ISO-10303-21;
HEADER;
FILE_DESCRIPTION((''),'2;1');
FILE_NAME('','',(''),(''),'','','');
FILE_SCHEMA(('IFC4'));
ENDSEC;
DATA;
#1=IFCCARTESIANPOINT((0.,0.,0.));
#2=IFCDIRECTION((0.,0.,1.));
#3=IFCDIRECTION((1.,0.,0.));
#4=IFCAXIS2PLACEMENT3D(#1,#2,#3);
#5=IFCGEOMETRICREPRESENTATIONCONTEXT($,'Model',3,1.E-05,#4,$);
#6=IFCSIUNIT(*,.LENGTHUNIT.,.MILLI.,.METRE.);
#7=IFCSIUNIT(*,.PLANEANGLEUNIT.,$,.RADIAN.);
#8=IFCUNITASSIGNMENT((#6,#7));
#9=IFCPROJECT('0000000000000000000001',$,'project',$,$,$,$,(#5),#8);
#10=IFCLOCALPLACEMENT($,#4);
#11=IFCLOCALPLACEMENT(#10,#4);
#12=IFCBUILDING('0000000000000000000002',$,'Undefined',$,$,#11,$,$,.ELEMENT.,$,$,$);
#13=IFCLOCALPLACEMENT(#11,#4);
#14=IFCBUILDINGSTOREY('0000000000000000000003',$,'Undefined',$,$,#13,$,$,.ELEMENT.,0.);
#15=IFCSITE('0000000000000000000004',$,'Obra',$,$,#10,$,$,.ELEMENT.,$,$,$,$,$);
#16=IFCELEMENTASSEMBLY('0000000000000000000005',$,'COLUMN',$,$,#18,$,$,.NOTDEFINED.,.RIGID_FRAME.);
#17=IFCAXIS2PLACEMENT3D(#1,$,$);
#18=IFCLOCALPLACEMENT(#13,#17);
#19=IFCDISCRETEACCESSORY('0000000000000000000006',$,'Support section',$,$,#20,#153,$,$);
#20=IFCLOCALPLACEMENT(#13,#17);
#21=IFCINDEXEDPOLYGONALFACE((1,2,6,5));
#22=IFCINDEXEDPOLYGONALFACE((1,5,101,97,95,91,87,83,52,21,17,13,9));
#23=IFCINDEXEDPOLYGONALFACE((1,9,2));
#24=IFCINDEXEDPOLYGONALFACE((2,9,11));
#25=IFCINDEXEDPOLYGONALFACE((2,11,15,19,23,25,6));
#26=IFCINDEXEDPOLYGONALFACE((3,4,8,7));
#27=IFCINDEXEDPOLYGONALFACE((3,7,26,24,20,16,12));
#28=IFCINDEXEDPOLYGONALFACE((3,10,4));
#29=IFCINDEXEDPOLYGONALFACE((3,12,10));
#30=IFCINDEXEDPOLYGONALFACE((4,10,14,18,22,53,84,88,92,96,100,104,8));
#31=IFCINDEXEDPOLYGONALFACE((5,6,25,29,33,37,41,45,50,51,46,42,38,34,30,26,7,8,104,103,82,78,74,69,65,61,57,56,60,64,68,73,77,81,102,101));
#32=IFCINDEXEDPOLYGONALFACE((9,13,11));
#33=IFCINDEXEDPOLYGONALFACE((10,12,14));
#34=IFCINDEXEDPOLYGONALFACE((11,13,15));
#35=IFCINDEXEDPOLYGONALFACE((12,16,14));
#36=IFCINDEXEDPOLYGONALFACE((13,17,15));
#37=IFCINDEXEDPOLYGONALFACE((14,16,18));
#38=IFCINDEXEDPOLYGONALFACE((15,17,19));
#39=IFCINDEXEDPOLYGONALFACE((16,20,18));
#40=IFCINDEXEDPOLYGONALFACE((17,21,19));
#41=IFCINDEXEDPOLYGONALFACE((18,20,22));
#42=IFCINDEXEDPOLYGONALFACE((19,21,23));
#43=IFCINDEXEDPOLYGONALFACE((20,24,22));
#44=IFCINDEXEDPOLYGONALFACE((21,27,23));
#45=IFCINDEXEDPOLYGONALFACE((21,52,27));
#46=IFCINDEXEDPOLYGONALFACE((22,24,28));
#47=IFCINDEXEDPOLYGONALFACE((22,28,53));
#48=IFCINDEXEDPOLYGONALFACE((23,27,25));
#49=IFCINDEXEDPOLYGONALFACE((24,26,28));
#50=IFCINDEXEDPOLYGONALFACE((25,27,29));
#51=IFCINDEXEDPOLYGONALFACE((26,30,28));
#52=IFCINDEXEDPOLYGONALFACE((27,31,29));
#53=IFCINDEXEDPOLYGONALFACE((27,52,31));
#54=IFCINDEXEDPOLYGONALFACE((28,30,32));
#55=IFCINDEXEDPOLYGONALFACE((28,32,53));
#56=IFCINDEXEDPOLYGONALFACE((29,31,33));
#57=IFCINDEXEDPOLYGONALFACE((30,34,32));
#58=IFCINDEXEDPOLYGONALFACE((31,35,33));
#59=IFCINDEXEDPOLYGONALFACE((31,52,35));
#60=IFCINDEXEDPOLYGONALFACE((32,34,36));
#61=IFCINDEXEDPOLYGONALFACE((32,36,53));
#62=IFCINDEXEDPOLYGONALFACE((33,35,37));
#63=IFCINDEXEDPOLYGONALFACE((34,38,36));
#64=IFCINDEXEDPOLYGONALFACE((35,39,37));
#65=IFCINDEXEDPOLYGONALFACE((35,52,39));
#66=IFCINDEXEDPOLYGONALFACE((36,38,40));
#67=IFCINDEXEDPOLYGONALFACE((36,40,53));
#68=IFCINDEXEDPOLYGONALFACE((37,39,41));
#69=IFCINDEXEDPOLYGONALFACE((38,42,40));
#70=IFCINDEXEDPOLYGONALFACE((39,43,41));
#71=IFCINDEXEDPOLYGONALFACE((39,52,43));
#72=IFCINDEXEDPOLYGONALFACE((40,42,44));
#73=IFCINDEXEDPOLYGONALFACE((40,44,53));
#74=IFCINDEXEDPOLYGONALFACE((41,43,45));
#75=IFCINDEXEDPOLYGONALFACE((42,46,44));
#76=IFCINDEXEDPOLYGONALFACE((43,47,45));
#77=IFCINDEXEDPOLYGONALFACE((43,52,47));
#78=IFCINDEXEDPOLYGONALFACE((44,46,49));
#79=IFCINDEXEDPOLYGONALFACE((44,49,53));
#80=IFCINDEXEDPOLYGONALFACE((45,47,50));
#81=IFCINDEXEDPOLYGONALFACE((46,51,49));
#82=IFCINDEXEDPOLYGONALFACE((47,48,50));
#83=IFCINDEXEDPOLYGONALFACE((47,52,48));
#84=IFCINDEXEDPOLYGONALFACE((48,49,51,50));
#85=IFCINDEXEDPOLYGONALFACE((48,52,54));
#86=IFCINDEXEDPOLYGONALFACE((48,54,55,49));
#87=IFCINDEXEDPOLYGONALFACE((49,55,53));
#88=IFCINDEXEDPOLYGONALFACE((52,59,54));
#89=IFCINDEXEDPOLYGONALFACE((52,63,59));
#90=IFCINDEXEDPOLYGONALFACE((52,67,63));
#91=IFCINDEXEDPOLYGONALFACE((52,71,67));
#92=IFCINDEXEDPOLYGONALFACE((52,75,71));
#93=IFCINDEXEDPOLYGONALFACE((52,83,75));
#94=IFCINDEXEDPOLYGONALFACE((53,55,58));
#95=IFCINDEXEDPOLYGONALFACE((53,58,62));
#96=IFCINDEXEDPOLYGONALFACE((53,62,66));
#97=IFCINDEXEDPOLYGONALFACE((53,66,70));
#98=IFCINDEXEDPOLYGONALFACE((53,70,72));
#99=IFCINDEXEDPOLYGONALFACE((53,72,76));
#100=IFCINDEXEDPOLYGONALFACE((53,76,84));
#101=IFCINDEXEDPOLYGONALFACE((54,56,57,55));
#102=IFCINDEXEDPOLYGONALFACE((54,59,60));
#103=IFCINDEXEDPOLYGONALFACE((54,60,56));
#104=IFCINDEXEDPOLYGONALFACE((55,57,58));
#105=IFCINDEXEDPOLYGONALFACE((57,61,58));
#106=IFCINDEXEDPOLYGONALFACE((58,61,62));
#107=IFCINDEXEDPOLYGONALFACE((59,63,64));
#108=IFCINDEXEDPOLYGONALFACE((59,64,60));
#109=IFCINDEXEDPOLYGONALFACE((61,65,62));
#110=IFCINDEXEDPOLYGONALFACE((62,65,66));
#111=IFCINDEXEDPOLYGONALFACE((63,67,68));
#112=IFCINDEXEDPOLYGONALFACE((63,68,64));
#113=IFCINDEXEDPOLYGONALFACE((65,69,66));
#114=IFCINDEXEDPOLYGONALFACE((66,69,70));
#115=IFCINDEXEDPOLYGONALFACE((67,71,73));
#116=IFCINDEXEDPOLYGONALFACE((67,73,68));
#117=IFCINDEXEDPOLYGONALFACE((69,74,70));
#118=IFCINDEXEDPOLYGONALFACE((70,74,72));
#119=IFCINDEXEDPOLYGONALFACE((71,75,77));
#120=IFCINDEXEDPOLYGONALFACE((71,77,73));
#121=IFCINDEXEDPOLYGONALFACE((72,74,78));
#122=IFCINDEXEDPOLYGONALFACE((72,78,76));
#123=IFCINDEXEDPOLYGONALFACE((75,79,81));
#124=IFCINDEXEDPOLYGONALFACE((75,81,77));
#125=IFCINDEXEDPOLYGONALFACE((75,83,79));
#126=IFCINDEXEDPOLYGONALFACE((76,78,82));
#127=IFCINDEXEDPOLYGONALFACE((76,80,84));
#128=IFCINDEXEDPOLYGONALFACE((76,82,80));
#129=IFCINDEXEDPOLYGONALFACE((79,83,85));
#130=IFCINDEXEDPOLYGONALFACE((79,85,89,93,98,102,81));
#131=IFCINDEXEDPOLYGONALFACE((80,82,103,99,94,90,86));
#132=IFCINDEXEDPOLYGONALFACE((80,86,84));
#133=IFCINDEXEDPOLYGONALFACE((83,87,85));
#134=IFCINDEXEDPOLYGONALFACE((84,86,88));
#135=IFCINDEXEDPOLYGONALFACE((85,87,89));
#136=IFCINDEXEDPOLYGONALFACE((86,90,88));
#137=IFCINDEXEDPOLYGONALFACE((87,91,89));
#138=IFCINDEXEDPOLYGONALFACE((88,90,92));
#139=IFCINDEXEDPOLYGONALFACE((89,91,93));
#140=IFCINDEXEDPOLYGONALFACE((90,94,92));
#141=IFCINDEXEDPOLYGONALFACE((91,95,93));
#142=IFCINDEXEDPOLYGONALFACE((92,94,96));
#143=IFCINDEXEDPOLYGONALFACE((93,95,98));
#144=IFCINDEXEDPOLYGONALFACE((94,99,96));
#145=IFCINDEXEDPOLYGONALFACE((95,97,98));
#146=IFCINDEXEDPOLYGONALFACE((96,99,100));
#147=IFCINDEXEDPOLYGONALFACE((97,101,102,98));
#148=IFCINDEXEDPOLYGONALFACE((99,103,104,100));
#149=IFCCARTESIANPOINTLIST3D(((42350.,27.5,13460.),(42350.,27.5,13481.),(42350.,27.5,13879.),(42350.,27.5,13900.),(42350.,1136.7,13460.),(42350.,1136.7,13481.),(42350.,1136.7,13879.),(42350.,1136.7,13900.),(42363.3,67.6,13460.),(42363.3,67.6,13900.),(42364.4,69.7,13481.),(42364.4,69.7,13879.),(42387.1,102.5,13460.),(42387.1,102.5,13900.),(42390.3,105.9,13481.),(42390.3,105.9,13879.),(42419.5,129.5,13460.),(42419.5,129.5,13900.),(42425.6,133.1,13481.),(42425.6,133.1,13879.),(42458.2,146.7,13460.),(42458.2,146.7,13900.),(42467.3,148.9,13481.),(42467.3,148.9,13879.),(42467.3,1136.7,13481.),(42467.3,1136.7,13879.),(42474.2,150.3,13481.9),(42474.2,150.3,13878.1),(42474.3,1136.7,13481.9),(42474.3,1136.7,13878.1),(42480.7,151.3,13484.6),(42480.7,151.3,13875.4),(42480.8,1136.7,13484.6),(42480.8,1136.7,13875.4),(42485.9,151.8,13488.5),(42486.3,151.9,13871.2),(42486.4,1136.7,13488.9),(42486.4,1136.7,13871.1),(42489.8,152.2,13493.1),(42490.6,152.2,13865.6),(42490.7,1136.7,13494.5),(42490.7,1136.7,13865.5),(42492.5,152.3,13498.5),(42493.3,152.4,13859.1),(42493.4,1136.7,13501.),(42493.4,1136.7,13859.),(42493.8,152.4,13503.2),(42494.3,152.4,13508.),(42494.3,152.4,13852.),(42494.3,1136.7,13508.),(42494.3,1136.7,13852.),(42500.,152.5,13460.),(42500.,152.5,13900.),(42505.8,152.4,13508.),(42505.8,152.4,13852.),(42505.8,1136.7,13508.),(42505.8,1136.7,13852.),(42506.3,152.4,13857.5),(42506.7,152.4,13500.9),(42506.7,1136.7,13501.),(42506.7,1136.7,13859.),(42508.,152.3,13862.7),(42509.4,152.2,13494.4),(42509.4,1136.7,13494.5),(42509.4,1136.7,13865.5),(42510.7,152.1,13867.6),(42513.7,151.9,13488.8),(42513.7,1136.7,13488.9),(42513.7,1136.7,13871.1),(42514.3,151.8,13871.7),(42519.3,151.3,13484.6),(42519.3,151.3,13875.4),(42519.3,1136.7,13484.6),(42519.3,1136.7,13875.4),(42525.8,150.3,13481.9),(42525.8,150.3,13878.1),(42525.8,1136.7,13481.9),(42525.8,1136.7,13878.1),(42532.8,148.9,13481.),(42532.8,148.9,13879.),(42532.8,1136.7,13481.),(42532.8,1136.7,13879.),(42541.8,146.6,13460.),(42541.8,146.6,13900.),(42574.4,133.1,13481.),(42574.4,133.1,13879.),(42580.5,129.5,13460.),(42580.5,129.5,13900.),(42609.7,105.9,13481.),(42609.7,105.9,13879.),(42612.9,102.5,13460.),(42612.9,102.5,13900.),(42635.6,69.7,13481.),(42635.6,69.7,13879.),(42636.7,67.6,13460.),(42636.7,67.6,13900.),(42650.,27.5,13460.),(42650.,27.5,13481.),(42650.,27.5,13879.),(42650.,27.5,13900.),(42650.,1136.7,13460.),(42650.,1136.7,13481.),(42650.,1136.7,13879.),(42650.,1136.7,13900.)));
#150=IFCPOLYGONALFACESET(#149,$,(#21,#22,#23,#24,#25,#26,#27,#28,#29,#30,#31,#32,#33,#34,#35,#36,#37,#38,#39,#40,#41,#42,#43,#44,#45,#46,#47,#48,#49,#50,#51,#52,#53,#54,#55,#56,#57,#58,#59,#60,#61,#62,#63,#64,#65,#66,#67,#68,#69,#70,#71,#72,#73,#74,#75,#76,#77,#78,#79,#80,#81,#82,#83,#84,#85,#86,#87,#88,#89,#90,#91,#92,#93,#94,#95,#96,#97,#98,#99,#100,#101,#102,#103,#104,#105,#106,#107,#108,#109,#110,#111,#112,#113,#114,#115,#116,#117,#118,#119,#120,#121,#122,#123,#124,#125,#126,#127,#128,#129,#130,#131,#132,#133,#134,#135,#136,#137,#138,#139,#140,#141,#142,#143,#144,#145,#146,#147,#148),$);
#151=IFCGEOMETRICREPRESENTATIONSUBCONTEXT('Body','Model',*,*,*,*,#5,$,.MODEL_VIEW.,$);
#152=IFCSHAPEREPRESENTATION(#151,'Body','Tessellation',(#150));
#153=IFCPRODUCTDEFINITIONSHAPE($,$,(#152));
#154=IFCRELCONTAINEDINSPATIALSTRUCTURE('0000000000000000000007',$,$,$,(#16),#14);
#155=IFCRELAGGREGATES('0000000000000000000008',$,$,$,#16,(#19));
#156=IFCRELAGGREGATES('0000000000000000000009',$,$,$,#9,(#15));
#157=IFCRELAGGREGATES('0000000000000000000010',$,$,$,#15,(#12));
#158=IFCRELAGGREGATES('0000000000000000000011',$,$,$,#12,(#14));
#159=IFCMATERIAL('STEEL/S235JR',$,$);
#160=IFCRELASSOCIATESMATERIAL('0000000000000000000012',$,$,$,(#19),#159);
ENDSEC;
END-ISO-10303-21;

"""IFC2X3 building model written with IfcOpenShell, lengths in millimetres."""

from ifc_helpers import new_model, si_unit, frame, origin_with_axes, origin_2d_with_axis, place, context, subcontext, project, spatial, circle, i_section, extrude, clip, halfspace, material, element, aggregate, save


model = new_model("IFC2X3")

# Units and contexts
model_context = context("Model", 3, precision=1e-05, world=origin_with_axes())
body_context = subcontext(model_context, "Body", "Model", "MODEL_VIEW")
ifc_project = project(units=[si_unit("LENGTHUNIT", "METRE", prefix="MILLI"), si_unit("PLANEANGLEUNIT", "RADIAN")], contexts=[model_context])

# Site, building, storey
site_placement = place(None, origin_with_axes())
site = spatial("IfcSite", under=ifc_project, at=site_placement, Name="Obra", CompositionType="ELEMENT")
building_placement = place(site_placement, origin_with_axes())
building = spatial("IfcBuilding", under=site, at=building_placement, Name="Undefined", CompositionType="ELEMENT")
storey_placement = place(building_placement, origin_with_axes())
storey = spatial("IfcBuildingStorey", under=building, at=storey_placement, Name="Undefined", CompositionType="ELEMENT", Elevation=0.0)

# Element assembly
assembly_1_placement = place(storey_placement, origin_with_axes())
assembly_1 = element("IfcElementAssembly", 1, at=assembly_1_placement, inside=storey, Name="COLUMN", AssemblyPlace="NOTDEFINED", PredefinedType="RIGID_FRAME")
ifc_material_1 = material(Name="STEEL/S235JR")

# Discrete accessory, opening
discrete_accessory_1_placement = place(assembly_1_placement, frame((42500.0, 0.0, 13680.0), z_axis=(0.0, 0.0, 1.0), x_axis=(0.000019, 1.0, 0.0)))
discrete_accessory_1 = element("IfcDiscreteAccessory", 2, at=discrete_accessory_1_placement, material=ifc_material_1, Name="Support section", context=body_context, shape_type="Clipping", body=[
    clip(extrude(i_section(OverallWidth=300.0, OverallDepth=440.0, WebThickness=11.5, FlangeThickness=21.0, FilletRadius=27.0, at=origin_2d_with_axis()), frame((1136.7, 0.0, 0.0), z_axis=(-1.0, 0.0, 0.0), x_axis=(0.0, -1.0, 0.0)), (0.0, 0.0, 1.0), 1136.7), halfspace(frame((1136.7, -1000.0, 0.0), z_axis=(-1.0, -0.000019, 0.0), x_axis=(0.0, 0.0, -1.0)), True)),
])
opening_1_placement = place(assembly_1_placement, frame((42500.0, 0.0, 13680.0), z_axis=(0.0, 0.0, 1.0), x_axis=(0.000019, 1.0, 0.0)))
element("IfcOpeningElement", 3, at=opening_1_placement, cuts=discrete_accessory_1, ObjectType="Recess", context=body_context, shape_type="SweptSolid", body=[
    extrude(circle(Radius=152.5, at=origin_2d_with_axis()), frame((0.0, 0.0, -280.0), z_axis=(0.0, 0.0, 1.0), x_axis=(-1.0, 0.0, 0.0)), (0.0, 0.0, 1.0), 560.0),
])
aggregate(assembly_1, [discrete_accessory_1])

save(model, "model.ifc")
